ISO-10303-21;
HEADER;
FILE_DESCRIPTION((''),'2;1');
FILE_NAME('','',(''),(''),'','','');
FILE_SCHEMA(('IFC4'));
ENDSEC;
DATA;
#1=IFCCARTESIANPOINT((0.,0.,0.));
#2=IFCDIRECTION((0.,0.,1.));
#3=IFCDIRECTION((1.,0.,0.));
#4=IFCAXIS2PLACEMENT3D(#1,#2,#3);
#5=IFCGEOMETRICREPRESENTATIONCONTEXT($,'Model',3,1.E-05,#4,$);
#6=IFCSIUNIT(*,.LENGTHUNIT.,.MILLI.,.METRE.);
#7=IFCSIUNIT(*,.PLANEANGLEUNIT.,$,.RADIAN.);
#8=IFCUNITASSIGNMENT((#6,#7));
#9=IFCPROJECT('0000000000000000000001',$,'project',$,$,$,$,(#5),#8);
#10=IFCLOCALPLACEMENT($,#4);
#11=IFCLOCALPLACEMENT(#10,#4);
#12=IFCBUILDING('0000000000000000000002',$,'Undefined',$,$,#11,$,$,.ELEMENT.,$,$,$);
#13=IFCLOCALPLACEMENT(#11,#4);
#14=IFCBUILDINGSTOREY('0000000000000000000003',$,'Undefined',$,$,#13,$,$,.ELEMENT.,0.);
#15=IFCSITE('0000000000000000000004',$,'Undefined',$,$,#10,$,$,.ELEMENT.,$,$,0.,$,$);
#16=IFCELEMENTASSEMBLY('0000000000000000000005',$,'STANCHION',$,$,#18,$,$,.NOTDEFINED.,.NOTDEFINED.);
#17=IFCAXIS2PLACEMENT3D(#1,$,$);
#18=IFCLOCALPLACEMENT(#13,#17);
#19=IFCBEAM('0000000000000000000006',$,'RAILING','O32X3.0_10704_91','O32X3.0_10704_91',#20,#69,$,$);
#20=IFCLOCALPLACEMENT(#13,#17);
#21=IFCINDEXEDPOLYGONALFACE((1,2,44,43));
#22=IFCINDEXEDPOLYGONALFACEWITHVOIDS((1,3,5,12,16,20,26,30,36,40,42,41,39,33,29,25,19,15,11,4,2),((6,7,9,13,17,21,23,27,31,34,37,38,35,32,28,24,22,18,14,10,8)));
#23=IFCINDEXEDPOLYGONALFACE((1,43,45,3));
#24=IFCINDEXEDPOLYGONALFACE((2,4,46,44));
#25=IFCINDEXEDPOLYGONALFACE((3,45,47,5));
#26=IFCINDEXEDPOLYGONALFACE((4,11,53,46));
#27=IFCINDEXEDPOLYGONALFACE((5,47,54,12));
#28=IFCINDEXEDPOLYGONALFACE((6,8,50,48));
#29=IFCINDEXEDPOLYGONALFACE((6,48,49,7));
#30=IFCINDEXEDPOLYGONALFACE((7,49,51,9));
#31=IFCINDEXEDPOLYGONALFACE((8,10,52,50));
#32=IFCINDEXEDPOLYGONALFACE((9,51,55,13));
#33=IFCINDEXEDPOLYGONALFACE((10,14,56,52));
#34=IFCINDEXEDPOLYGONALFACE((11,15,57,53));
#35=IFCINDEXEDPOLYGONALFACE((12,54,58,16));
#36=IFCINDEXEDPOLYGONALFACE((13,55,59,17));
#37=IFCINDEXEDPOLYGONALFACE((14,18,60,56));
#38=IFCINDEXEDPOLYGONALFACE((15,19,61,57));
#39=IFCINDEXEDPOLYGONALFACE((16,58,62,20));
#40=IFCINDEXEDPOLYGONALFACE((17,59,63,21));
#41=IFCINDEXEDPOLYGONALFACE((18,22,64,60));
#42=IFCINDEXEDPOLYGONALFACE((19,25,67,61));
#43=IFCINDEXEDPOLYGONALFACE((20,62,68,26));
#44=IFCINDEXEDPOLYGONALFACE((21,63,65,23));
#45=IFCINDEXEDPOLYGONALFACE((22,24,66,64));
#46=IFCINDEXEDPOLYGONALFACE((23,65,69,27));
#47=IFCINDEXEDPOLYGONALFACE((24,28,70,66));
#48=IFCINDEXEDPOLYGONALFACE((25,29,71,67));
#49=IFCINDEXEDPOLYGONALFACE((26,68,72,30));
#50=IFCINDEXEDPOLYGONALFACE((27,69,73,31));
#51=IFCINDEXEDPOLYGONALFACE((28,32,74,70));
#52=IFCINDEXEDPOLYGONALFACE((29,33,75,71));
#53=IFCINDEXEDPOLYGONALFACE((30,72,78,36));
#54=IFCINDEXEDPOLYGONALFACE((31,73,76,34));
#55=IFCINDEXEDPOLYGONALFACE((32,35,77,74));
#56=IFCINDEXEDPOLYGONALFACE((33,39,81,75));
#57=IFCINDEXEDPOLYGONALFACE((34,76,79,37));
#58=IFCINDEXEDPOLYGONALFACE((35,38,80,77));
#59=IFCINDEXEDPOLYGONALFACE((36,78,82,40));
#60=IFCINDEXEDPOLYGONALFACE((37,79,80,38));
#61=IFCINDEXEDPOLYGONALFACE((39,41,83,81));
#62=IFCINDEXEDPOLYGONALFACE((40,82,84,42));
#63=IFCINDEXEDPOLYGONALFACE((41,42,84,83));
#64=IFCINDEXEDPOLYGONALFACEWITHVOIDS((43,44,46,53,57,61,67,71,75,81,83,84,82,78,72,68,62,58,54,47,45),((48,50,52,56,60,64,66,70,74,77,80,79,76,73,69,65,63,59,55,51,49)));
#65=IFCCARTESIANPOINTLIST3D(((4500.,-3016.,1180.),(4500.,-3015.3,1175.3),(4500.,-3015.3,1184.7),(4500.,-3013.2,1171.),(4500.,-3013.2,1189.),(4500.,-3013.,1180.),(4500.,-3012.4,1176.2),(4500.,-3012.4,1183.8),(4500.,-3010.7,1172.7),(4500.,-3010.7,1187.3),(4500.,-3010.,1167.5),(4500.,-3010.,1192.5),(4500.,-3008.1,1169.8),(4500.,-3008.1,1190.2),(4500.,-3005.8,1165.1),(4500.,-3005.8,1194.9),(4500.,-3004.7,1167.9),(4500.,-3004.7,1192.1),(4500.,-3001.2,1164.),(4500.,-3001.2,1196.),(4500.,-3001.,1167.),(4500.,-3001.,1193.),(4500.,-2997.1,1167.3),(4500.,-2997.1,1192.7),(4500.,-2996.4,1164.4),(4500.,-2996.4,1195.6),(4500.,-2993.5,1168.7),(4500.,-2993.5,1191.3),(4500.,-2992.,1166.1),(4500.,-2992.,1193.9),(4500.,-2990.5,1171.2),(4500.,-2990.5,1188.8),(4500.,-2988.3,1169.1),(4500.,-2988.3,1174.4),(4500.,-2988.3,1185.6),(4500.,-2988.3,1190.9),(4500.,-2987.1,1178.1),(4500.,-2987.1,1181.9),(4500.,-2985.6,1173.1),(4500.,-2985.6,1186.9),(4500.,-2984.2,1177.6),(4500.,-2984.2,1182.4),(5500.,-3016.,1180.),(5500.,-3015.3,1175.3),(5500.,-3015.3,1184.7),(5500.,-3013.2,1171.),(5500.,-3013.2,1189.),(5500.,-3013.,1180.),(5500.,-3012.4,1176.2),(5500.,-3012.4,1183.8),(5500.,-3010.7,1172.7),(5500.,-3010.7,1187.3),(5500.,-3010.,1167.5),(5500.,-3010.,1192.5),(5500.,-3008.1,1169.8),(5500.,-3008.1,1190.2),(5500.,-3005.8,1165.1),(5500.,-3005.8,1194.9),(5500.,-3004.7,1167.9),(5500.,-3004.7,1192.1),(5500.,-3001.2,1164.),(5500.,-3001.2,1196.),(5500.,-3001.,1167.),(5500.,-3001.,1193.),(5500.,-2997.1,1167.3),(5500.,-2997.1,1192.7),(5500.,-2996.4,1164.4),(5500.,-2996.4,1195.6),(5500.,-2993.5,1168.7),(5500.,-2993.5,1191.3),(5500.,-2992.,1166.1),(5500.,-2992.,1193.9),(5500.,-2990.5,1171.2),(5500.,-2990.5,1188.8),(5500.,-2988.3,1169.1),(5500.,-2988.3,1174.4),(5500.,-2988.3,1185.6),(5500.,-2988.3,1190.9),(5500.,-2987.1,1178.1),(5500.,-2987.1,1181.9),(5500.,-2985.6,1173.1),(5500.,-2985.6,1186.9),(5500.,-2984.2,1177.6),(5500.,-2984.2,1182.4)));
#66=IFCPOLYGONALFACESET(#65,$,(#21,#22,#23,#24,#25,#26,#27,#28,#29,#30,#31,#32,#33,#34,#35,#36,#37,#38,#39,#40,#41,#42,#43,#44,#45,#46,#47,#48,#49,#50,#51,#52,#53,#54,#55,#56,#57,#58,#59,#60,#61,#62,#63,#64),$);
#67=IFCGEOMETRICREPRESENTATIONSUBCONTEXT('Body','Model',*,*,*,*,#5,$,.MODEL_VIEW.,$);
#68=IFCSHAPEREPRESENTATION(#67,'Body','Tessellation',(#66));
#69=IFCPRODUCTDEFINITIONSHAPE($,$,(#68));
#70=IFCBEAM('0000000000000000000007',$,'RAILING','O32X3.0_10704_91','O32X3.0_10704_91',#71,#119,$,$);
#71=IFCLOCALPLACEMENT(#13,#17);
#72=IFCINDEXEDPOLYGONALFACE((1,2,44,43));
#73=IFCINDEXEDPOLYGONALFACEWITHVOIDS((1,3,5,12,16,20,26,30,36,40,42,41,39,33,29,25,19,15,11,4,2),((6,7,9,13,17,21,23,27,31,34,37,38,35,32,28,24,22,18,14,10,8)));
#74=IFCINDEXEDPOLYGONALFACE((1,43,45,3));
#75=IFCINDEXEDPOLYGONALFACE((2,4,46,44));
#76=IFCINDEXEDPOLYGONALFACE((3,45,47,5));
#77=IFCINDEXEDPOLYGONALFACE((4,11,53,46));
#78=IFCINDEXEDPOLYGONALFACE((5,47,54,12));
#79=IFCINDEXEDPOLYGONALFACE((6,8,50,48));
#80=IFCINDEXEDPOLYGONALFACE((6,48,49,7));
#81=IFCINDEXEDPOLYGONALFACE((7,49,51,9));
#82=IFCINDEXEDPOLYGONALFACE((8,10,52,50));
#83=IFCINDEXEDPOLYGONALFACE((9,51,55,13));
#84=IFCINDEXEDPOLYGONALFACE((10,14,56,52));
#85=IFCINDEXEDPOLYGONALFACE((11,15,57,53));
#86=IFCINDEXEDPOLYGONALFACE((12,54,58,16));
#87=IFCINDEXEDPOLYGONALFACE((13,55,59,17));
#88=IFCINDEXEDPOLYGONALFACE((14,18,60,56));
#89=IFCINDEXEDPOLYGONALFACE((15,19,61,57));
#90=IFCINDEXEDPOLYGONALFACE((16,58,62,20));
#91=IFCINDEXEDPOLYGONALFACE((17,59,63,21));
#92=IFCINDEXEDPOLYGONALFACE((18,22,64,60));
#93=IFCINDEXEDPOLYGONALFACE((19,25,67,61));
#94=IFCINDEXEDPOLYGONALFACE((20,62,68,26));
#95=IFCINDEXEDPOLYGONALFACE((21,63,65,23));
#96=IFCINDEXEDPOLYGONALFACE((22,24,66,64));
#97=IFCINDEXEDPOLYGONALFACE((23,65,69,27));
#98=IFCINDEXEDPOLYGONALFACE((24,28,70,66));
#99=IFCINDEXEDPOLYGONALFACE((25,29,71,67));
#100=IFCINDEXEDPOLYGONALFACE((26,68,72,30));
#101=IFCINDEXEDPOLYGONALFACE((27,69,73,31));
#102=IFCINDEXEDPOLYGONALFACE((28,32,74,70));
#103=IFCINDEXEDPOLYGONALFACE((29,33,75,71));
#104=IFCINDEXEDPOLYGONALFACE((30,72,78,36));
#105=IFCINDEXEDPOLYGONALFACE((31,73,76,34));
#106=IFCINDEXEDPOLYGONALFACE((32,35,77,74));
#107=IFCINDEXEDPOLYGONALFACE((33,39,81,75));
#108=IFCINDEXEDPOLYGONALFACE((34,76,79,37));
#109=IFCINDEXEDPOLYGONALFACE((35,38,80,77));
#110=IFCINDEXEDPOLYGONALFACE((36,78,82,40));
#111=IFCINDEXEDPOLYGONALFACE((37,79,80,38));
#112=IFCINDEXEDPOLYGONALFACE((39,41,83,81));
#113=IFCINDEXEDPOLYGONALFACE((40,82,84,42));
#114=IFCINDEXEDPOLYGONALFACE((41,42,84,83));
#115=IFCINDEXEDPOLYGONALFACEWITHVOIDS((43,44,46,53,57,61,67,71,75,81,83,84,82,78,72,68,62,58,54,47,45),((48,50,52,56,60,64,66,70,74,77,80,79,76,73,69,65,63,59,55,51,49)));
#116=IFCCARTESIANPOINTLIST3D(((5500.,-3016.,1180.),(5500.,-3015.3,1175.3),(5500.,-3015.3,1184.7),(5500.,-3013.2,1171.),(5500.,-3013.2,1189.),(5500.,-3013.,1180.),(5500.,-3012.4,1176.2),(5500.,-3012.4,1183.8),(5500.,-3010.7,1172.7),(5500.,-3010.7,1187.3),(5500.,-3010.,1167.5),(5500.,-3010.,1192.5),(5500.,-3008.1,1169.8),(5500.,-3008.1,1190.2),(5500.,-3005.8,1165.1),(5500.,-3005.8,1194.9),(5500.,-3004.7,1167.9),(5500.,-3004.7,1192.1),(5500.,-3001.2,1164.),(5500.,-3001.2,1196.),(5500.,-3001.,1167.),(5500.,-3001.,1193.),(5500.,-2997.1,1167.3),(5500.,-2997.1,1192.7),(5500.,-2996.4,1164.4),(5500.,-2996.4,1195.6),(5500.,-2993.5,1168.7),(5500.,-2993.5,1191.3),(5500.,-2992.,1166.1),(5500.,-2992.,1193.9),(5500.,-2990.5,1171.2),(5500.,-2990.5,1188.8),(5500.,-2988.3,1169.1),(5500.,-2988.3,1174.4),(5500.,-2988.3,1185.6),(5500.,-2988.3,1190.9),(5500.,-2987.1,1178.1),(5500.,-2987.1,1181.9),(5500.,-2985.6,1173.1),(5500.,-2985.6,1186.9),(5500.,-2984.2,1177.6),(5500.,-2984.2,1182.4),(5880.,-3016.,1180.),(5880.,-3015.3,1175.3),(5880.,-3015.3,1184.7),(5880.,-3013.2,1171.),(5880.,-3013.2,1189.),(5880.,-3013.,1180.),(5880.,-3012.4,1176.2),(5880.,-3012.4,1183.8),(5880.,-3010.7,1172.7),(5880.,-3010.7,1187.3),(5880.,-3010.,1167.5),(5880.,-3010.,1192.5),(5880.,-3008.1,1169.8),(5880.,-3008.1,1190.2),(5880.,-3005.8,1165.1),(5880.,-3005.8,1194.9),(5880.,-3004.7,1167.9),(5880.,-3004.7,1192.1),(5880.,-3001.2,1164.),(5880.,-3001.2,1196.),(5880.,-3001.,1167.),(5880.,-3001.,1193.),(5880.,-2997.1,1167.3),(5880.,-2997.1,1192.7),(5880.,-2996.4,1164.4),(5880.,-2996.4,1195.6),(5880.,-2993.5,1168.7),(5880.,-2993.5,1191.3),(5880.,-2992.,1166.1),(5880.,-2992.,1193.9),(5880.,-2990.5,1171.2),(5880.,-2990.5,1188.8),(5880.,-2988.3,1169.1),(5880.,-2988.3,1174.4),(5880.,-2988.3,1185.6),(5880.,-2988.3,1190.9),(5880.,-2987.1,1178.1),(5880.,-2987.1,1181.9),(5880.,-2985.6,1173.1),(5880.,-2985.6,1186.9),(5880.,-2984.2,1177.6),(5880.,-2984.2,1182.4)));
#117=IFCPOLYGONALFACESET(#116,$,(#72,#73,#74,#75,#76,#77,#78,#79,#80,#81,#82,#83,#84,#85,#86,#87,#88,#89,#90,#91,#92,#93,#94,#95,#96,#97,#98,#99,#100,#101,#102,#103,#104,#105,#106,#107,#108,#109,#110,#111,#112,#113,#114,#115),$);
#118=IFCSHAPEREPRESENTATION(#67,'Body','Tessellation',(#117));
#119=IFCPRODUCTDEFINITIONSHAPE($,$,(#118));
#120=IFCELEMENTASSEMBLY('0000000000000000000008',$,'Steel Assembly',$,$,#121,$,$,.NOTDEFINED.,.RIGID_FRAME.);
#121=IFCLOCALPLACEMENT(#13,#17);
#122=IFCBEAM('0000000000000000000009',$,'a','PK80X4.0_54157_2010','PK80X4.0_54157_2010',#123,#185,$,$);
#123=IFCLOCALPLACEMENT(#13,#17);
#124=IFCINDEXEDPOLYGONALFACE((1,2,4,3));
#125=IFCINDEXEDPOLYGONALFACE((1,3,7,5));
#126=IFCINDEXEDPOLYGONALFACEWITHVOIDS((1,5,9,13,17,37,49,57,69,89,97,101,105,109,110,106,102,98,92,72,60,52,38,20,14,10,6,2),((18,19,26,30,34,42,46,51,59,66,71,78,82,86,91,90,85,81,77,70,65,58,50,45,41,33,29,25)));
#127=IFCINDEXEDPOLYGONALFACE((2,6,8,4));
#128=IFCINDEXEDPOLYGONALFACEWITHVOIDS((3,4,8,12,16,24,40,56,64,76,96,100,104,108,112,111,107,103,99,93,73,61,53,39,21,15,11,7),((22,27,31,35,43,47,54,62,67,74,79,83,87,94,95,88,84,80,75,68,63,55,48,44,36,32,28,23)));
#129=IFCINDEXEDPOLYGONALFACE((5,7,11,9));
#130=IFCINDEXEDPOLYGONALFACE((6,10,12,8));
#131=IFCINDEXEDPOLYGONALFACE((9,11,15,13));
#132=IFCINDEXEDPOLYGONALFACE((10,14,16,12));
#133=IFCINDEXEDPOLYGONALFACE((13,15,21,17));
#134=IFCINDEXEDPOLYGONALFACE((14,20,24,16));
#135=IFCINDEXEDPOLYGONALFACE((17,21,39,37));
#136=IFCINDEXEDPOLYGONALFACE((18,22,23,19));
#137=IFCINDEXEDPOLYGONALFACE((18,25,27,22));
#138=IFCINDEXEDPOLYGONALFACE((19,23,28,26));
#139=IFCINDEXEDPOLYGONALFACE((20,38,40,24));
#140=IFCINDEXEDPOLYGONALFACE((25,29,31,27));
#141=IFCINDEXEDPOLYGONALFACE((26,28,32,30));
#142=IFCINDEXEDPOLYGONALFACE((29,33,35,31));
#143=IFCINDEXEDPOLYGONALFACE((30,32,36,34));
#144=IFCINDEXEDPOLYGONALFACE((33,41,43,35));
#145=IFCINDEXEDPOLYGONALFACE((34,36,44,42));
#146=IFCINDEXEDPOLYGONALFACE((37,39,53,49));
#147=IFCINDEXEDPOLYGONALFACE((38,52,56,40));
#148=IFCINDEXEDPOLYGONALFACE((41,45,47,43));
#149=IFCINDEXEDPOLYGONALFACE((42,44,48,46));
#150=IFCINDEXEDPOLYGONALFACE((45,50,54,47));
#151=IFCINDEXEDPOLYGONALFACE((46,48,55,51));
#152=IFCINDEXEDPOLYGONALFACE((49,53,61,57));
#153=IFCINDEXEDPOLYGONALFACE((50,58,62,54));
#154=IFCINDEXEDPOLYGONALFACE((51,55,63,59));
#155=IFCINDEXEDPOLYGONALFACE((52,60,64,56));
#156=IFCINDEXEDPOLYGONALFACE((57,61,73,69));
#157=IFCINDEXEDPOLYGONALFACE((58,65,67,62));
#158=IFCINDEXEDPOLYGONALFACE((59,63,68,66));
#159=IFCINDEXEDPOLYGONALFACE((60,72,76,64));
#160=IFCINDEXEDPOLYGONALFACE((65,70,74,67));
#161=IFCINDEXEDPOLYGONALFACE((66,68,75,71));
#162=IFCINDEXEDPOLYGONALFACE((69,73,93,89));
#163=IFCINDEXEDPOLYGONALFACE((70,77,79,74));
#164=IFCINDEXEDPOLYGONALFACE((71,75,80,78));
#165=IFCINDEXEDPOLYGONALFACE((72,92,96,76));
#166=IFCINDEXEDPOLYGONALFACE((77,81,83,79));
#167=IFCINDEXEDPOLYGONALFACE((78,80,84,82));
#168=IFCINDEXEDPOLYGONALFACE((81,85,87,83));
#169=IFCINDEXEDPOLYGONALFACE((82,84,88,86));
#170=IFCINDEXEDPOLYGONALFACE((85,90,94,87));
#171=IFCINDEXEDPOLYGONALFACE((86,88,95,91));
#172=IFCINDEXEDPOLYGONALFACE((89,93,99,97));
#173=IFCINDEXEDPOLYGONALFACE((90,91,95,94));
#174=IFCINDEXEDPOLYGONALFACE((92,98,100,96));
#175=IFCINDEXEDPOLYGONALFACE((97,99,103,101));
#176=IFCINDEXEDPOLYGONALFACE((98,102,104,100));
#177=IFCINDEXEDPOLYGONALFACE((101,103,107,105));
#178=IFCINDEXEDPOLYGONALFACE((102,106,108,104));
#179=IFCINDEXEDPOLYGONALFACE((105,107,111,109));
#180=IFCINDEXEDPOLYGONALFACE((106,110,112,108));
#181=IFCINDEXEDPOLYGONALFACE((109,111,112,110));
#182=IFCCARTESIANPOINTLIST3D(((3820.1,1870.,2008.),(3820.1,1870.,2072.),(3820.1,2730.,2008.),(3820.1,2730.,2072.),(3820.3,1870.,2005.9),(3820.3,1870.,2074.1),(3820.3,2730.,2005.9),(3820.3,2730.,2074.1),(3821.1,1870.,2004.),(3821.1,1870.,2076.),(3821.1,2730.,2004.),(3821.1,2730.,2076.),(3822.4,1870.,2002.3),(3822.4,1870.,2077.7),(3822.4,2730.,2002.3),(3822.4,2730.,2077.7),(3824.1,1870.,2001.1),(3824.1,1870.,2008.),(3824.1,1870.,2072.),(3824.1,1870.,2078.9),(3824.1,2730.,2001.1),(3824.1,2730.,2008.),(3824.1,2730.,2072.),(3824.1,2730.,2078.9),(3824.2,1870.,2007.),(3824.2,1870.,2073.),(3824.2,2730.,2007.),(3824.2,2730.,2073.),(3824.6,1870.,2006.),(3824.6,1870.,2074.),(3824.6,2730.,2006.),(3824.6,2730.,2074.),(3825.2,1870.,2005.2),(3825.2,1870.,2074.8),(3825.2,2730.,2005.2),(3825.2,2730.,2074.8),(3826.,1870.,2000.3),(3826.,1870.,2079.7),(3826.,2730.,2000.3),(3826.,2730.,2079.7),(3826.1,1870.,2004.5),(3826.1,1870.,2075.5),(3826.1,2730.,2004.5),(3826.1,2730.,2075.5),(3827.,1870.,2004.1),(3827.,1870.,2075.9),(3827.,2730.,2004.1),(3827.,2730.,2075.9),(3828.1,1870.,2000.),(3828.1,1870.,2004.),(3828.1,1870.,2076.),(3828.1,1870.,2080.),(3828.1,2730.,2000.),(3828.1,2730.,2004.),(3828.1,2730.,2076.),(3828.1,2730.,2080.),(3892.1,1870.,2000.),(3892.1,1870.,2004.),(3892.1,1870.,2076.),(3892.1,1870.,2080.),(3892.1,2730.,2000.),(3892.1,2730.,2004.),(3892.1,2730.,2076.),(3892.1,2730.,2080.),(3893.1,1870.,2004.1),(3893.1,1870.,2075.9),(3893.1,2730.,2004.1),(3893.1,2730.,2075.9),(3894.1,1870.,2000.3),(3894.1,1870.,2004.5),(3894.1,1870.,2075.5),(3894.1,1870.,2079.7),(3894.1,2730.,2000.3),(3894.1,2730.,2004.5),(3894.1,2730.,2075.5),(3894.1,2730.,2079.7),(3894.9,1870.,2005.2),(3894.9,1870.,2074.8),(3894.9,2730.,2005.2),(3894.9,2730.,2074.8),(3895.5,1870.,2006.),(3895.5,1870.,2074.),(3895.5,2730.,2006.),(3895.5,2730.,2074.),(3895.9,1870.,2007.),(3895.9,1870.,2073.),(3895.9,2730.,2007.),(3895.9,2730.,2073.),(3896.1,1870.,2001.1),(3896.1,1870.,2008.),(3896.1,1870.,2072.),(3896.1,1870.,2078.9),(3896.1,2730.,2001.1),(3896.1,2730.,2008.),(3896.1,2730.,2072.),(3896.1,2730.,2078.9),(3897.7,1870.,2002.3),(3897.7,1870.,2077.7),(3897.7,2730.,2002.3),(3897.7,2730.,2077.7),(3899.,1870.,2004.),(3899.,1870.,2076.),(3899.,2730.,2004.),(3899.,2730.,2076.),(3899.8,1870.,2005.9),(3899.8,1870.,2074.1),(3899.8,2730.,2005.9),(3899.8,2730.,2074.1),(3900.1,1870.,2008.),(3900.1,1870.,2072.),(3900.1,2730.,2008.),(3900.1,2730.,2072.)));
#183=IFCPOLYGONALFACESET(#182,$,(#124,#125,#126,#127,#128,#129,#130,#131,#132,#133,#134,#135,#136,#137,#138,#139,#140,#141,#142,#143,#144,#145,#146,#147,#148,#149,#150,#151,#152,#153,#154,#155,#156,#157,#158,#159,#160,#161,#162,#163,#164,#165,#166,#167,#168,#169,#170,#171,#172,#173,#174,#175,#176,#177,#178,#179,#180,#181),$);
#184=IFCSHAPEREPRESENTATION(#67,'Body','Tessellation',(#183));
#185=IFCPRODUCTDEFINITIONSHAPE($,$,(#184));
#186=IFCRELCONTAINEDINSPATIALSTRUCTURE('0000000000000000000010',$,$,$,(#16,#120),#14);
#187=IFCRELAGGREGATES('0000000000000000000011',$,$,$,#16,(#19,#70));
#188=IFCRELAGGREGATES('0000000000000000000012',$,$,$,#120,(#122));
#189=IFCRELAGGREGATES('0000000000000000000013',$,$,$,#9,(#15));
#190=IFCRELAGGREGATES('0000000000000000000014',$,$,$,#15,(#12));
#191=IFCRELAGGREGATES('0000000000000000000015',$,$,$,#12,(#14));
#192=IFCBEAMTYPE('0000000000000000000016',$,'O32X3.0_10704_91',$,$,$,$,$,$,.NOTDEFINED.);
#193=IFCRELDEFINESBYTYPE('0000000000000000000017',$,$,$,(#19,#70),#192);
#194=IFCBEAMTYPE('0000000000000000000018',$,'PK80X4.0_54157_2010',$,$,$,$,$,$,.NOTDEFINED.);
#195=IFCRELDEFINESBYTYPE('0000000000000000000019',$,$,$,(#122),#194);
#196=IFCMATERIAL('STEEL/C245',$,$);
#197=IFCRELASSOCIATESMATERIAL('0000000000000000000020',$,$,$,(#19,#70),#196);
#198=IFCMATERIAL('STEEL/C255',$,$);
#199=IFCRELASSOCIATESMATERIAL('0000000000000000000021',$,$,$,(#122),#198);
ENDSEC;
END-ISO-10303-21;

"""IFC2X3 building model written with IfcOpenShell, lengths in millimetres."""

from ifc_helpers import new_model, si_unit, frame, origin_with_axes, origin_2d_with_axis, place, context, subcontext, project, spatial, hollow_rectangle, hollow_circle, extrude, material, type_object, element, aggregate, save


model = new_model("IFC2X3")

# Units and contexts
model_context = context("Model", 3, precision=1e-05, world=origin_with_axes())
body_context = subcontext(model_context, "Body", "Model", "MODEL_VIEW")
ifc_project = project(units=[si_unit("LENGTHUNIT", "METRE", prefix="MILLI"), si_unit("PLANEANGLEUNIT", "RADIAN")], contexts=[model_context])

# Site, building, storey
site_placement = place(None, origin_with_axes())
site = spatial("IfcSite", under=ifc_project, at=site_placement, Name="Undefined", CompositionType="ELEMENT", RefElevation=0.0)
building_placement = place(site_placement, origin_with_axes())
building = spatial("IfcBuilding", under=site, at=building_placement, Name="Undefined", CompositionType="ELEMENT")
storey_placement = place(building_placement, origin_with_axes())
storey = spatial("IfcBuildingStorey", under=building, at=storey_placement, Name="Undefined", CompositionType="ELEMENT", Elevation=0.0)

# Element assembly, beams
assembly_1_placement = place(storey_placement, origin_with_axes())
assembly_1 = element("IfcElementAssembly", 1, at=assembly_1_placement, inside=storey, Name="STANCHION", AssemblyPlace="NOTDEFINED", PredefinedType="NOTDEFINED")
ifc_material_1 = material(Name="STEEL/C245")
beam_type_1 = type_object("IfcBeamType", Name="O32X3.0_10704_91", PredefinedType="NOTDEFINED")
beam_1_placement = place(assembly_1_placement, frame((5500.0, -3000.0, 1180.0), z_axis=(0.0, 0.0, -1.0), x_axis=(-1.0, 0.0, 0.0)))
beam_1 = element("IfcBeam", 2, at=beam_1_placement, type_object=beam_type_1, material=ifc_material_1, Name="RAILING", Description="O32X3.0_10704_91", ObjectType="O32X3.0_10704_91", context=body_context, shape_type="SweptSolid", body=[
    extrude(hollow_circle(Radius=16.0, WallThickness=3.0, at=origin_2d_with_axis()), frame((1000.0, 0.0, 0.0), z_axis=(-1.0, 0.0, 0.0), x_axis=(0.0, -1.0, 0.0)), (0.0, 0.0, 1.0), 1000.0),
])
beam_2_placement = place(assembly_1_placement, frame((5880.0, -3000.0, 1180.0), z_axis=(0.0, 0.0, -1.0), x_axis=(-1.0, 0.0, 0.0)))
beam_2 = element("IfcBeam", 3, at=beam_2_placement, type_object=beam_type_1, material=ifc_material_1, Name="RAILING", Description="O32X3.0_10704_91", ObjectType="O32X3.0_10704_91", context=body_context, shape_type="SweptSolid", body=[
    extrude(hollow_circle(Radius=16.0, WallThickness=3.0, at=origin_2d_with_axis()), frame((380.0, 0.0, 0.0), z_axis=(-1.0, 0.0, 0.0), x_axis=(0.0, -1.0, 0.0)), (0.0, 0.0, 1.0), 380.0),
])
aggregate(assembly_1, [beam_1, beam_2])

# Element assembly, beam
assembly_2_placement = place(storey_placement, origin_with_axes())
assembly_2 = element("IfcElementAssembly", 4, at=assembly_2_placement, inside=storey, Name="Steel Assembly", AssemblyPlace="NOTDEFINED", PredefinedType="RIGID_FRAME")
ifc_material_2 = material(Name="STEEL/C255")
beam_type_2 = type_object("IfcBeamType", Name="PK80X4.0_54157_2010", PredefinedType="NOTDEFINED")
beam_3_placement = place(assembly_2_placement, frame((3860.1, 1870.0, 2040.0), z_axis=(0.0, 0.0, 1.0), x_axis=(0.0, 1.0, 0.0)))
beam_3 = element("IfcBeam", 5, at=beam_3_placement, type_object=beam_type_2, material=ifc_material_2, Name="a", Description="PK80X4.0_54157_2010", ObjectType="PK80X4.0_54157_2010", context=body_context, shape_type="SweptSolid", body=[
    extrude(hollow_rectangle(XDim=80.0, YDim=80.0, WallThickness=4.0, InnerFilletRadius=4.0, OuterFilletRadius=8.0, at=origin_2d_with_axis()), frame((860.0, 0.0, 0.0), z_axis=(-1.0, 0.0, 0.0), x_axis=(0.0, -1.0, 0.0)), (0.0, 0.0, 1.0), 860.0),
])
aggregate(assembly_2, [beam_3])

save(model, "model.ifc")
